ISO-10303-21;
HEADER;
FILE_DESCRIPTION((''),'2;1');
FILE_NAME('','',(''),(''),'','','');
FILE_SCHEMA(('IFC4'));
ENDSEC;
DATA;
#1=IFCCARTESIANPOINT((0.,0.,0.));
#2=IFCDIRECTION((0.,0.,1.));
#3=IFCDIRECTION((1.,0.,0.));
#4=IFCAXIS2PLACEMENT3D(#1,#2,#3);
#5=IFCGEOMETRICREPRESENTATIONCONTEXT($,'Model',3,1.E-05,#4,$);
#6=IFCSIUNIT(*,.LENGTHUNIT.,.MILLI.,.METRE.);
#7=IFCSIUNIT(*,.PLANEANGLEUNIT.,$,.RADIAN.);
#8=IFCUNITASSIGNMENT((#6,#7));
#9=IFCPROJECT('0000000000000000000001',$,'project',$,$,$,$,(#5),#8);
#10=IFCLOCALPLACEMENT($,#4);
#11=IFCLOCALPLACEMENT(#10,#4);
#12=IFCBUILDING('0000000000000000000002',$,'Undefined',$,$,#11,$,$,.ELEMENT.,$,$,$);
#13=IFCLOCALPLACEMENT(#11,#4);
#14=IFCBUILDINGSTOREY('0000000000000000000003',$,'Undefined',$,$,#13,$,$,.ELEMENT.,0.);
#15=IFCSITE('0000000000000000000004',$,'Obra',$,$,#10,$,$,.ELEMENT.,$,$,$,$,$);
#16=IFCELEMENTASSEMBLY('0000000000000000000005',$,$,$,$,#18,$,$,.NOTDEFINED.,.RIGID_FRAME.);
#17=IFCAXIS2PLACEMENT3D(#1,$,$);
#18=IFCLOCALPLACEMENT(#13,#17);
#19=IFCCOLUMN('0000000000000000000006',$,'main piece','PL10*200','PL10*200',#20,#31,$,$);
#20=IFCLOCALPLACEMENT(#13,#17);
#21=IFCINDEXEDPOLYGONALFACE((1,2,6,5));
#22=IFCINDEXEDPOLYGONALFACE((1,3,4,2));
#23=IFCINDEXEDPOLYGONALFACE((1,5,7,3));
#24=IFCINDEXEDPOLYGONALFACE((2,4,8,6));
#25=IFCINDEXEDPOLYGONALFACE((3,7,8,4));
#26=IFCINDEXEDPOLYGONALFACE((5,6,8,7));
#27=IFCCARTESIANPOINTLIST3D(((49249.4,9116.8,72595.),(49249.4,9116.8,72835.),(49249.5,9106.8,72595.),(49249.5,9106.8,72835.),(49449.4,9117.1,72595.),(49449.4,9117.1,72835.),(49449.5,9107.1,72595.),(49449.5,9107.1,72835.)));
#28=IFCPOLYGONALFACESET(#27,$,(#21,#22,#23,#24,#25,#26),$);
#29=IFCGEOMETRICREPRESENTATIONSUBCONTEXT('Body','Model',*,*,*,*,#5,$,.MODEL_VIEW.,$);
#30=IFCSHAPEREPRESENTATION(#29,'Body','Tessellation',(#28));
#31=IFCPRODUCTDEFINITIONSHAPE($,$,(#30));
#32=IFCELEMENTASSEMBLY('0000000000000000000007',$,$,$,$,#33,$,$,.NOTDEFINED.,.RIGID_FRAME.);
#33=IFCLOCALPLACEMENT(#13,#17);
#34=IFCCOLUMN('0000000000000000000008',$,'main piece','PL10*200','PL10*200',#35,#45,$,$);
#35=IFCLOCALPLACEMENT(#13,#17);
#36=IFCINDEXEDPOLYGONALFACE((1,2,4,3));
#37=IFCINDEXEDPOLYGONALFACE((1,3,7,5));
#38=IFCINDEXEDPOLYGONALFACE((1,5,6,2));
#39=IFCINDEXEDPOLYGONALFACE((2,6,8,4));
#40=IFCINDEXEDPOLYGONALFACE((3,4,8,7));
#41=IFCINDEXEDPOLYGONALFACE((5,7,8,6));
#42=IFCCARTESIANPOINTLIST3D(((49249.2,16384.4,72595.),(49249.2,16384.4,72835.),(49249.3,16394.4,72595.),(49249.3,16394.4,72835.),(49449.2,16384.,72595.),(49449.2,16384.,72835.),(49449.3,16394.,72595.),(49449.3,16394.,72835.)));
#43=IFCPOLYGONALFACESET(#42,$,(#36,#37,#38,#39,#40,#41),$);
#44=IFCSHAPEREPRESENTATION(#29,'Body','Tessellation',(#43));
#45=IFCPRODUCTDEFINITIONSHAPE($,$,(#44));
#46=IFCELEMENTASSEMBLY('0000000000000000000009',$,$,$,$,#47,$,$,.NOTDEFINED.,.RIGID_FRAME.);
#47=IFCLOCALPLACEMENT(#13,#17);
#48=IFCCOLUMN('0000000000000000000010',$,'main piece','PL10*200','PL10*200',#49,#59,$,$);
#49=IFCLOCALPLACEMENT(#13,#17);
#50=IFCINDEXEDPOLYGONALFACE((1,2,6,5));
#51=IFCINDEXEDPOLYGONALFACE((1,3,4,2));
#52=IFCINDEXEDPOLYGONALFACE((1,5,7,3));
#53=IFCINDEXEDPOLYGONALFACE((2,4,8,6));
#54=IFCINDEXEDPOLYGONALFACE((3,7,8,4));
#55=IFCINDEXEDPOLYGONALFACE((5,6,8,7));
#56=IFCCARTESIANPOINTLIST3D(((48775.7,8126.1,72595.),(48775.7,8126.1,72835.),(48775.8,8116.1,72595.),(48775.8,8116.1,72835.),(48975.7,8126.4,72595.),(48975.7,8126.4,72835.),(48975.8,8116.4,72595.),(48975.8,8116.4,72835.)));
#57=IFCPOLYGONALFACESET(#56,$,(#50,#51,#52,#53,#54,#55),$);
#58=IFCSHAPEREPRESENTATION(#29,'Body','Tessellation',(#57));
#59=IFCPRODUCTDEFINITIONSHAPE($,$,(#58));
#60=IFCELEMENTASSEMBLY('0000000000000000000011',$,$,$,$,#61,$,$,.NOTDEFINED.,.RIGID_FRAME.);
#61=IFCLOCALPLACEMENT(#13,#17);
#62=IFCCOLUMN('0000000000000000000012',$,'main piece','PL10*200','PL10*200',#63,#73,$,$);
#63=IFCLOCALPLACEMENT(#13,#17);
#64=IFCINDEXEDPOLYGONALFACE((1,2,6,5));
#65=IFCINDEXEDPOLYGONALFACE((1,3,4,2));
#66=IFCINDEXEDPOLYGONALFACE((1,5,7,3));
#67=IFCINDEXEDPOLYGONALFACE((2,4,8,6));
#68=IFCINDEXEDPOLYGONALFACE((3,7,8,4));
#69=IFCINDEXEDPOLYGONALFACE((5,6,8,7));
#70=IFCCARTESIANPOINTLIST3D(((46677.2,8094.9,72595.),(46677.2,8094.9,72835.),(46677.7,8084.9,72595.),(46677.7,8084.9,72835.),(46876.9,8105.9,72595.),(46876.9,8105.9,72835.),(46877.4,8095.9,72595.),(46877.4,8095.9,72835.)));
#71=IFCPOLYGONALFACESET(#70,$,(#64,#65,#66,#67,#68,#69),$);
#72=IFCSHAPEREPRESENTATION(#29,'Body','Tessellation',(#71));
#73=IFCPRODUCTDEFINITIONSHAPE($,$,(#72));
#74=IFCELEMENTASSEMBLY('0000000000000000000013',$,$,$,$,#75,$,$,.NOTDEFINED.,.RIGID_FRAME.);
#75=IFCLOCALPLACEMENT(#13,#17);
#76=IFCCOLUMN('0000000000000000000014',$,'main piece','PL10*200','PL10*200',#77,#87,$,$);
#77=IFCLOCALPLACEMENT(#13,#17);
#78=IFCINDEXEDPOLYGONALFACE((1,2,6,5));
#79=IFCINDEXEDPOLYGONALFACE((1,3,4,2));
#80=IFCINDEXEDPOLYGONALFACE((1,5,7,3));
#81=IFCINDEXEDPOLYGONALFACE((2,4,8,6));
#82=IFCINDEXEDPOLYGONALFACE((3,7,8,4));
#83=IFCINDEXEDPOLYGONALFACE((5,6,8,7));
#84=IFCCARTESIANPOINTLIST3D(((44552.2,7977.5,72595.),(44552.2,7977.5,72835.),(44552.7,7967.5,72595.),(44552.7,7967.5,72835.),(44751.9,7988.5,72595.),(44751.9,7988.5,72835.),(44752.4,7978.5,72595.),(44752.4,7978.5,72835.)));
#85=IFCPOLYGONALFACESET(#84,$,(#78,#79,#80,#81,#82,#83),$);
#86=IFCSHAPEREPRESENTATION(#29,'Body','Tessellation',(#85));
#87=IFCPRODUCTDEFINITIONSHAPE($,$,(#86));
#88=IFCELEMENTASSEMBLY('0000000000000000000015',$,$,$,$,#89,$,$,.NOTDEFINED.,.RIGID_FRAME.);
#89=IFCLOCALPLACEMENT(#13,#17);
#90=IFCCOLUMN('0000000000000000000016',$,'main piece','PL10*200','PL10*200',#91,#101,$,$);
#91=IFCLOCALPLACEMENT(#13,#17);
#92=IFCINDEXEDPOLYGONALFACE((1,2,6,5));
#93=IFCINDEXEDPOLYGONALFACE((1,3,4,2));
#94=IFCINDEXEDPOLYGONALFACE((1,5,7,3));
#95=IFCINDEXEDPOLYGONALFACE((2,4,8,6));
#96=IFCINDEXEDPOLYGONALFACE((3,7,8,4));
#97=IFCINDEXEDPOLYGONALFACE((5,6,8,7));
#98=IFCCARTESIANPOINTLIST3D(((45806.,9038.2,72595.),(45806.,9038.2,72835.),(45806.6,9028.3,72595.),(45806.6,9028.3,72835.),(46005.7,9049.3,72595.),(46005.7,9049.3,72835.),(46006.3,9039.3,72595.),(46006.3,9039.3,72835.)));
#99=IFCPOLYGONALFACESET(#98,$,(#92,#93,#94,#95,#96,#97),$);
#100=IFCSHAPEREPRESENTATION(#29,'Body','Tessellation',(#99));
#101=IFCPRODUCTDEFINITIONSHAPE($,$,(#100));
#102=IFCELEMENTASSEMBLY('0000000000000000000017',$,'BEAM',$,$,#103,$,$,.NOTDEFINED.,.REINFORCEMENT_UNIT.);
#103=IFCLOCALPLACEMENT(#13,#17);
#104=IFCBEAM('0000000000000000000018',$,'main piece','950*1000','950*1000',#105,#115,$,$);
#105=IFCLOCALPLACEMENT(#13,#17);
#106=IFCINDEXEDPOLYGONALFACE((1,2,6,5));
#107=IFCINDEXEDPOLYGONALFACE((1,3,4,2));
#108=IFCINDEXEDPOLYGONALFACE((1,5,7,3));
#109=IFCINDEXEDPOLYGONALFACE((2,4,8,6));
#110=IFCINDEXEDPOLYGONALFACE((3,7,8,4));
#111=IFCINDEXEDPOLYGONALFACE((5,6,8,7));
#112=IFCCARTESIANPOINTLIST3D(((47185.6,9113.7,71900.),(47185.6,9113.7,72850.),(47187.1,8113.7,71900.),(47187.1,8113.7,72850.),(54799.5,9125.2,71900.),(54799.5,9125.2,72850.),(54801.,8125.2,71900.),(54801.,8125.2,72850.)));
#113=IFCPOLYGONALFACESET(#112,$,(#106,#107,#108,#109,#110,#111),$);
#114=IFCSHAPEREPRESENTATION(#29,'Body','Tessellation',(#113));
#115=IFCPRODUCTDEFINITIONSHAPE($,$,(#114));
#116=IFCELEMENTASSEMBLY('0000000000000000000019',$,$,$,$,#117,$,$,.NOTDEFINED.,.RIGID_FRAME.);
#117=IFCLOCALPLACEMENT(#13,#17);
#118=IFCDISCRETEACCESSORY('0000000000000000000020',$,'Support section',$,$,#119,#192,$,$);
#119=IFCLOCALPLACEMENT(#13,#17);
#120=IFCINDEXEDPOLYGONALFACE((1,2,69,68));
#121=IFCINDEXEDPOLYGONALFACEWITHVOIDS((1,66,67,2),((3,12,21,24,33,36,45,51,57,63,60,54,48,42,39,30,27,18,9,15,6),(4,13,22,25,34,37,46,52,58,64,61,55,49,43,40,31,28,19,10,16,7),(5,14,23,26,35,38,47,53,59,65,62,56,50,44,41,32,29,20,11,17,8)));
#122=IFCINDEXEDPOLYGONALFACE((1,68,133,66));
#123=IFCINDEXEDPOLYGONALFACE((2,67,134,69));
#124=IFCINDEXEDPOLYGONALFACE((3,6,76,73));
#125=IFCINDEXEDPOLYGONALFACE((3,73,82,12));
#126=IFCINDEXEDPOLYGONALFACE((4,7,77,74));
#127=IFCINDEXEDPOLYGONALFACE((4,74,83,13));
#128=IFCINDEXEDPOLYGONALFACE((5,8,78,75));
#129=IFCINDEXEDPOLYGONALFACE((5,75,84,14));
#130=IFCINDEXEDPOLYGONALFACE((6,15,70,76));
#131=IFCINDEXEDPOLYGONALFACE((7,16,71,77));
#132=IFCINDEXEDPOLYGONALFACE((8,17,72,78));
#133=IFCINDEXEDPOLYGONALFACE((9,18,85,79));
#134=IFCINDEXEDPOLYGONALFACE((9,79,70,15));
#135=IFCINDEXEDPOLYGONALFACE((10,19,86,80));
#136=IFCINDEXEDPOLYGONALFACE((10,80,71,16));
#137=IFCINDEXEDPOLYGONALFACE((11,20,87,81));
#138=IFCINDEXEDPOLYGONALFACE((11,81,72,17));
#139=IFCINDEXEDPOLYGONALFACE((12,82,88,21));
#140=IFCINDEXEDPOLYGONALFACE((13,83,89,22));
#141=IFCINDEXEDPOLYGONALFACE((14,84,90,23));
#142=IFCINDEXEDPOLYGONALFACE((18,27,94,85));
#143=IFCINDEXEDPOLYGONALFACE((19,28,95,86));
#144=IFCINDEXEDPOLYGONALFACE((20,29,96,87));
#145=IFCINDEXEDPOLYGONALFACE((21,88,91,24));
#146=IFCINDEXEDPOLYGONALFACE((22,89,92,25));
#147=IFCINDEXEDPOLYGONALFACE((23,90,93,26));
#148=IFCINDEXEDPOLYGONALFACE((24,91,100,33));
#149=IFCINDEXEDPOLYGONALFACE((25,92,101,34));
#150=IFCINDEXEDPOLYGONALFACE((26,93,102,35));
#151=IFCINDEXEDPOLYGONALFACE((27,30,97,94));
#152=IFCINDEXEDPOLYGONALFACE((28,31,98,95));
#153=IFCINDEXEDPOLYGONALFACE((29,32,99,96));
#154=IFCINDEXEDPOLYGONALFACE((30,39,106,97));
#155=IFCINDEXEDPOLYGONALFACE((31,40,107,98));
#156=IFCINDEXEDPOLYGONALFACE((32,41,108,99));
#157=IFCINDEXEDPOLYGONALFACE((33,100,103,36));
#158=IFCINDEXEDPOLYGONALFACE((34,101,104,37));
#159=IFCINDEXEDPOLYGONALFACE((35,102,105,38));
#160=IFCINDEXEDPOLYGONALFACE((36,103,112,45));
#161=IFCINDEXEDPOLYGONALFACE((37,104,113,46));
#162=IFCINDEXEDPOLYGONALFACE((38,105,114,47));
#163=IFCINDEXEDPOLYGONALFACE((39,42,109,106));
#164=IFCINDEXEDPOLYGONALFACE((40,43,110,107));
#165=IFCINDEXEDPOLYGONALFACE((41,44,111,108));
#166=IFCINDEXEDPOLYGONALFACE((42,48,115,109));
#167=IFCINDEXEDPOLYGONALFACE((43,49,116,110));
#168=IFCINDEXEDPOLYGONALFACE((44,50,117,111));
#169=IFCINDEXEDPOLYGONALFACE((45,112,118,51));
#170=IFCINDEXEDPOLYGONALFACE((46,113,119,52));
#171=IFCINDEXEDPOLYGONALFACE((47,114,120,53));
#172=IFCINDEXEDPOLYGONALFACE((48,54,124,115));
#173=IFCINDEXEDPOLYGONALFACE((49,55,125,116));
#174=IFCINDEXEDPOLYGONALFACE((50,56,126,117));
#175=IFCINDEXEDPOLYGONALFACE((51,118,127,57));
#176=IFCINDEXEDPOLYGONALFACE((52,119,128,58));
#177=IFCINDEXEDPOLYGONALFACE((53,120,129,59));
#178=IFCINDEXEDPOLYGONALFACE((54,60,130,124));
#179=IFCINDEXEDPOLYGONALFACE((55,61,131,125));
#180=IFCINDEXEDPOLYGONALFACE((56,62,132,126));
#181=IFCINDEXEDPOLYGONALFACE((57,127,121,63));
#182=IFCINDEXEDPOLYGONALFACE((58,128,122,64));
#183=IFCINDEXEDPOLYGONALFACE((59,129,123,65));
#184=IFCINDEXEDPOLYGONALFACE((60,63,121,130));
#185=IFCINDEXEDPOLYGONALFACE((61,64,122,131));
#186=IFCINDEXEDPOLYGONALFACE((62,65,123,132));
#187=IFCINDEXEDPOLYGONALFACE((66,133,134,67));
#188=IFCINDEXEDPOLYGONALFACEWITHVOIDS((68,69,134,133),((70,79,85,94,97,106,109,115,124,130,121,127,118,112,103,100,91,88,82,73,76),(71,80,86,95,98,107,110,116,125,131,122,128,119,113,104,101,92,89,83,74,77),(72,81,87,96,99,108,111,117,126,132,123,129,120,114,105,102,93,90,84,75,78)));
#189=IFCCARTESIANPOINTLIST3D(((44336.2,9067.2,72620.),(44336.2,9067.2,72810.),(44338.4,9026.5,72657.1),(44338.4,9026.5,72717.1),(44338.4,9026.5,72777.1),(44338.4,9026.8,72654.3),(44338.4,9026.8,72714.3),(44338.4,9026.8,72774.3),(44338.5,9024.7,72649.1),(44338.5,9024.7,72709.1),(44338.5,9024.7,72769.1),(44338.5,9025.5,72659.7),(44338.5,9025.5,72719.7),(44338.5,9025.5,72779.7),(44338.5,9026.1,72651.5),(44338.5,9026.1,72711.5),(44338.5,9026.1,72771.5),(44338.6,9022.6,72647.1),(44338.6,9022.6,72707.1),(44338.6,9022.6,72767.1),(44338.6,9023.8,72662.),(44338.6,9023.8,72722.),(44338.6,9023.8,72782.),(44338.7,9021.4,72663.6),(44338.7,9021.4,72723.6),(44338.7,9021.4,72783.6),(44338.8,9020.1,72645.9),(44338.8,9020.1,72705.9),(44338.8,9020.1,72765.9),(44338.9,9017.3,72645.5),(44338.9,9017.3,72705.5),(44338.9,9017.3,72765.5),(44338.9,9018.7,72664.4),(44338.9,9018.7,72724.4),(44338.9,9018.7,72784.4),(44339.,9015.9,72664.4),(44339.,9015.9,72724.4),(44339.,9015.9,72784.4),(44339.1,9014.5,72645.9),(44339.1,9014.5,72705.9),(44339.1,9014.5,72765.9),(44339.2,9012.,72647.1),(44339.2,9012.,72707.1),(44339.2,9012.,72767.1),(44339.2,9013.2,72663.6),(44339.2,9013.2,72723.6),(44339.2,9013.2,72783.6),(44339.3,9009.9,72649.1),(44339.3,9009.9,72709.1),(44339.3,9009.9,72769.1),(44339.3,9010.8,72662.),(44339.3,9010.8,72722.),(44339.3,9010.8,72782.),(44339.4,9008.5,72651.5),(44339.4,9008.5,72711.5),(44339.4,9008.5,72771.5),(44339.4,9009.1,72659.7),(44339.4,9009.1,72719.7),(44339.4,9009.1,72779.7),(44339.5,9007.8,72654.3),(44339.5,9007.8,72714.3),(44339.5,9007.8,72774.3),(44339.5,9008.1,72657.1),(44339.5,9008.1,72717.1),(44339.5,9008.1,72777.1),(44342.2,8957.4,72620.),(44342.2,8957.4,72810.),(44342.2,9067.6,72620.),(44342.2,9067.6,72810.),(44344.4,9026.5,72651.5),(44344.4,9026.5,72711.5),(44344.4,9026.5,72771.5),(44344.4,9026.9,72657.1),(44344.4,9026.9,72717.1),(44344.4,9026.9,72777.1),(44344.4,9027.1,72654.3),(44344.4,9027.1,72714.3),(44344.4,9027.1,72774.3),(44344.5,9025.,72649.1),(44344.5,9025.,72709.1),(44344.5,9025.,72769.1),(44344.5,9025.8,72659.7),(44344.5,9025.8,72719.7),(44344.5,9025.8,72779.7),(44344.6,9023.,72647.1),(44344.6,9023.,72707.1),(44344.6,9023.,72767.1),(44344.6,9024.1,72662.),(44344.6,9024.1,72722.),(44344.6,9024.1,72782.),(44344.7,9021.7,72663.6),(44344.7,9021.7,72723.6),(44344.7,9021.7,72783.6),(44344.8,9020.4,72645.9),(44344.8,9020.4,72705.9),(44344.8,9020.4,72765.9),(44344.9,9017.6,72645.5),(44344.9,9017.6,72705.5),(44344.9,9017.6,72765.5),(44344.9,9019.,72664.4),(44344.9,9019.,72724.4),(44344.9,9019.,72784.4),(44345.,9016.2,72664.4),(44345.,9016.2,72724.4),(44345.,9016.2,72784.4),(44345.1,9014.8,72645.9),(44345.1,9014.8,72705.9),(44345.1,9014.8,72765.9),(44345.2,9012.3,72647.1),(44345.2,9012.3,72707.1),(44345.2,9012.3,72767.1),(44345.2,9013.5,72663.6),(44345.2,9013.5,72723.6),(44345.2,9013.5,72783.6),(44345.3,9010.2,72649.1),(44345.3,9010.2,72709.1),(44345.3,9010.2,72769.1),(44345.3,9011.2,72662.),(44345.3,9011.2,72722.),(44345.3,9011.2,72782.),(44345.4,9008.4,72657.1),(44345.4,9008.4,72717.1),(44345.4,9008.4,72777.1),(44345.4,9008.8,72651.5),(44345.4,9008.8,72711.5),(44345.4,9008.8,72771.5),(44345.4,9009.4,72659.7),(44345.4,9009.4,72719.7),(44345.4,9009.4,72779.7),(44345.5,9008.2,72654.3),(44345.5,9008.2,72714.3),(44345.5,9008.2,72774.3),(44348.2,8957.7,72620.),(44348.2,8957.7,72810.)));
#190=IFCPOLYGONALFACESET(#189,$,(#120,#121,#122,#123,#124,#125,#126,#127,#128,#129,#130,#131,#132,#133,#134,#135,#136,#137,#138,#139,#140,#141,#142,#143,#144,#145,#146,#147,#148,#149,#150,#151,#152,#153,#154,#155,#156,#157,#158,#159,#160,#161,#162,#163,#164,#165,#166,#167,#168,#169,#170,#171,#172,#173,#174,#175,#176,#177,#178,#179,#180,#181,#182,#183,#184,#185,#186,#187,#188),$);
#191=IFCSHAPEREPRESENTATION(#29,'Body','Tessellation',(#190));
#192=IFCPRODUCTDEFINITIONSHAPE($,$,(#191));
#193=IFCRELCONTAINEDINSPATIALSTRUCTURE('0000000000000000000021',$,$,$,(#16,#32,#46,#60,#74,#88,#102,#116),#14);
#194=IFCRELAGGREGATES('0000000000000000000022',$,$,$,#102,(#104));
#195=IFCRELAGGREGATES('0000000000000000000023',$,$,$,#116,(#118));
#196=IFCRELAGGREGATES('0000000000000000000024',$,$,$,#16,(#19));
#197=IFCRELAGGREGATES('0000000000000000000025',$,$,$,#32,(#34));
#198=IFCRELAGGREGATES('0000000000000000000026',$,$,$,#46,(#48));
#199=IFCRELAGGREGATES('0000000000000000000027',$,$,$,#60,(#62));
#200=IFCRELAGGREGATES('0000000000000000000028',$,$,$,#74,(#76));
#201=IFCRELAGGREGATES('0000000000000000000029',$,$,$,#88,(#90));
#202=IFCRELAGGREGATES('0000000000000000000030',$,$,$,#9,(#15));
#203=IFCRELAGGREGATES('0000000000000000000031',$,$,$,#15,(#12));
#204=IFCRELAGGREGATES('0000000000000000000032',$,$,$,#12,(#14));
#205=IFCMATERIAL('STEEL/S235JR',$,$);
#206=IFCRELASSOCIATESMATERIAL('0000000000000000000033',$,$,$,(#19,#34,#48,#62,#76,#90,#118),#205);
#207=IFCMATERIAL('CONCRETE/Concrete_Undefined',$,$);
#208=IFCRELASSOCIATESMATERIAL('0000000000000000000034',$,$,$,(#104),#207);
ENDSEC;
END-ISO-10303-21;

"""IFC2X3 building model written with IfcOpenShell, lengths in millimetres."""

from ifc_helpers import new_model, si_unit, frame, origin_with_axes, origin_2d_with_axis, place, context, subcontext, project, spatial, rectangle, circle, extrude, source, transform, mapped, material, element, aggregate, save


model = new_model("IFC2X3")

# Units and contexts
model_context = context("Model", 3, precision=1e-05, world=origin_with_axes())
body_context = subcontext(model_context, "Body", "Model", "MODEL_VIEW")
ifc_project = project(units=[si_unit("LENGTHUNIT", "METRE", prefix="MILLI"), si_unit("PLANEANGLEUNIT", "RADIAN")], contexts=[model_context])

# Site, building, storey
site_placement = place(None, origin_with_axes())
site = spatial("IfcSite", under=ifc_project, at=site_placement, Name="Obra", CompositionType="ELEMENT")
building_placement = place(site_placement, origin_with_axes())
building = spatial("IfcBuilding", under=site, at=building_placement, Name="Undefined", CompositionType="ELEMENT")
storey_placement = place(building_placement, origin_with_axes())
storey = spatial("IfcBuildingStorey", under=building, at=storey_placement, Name="Undefined", CompositionType="ELEMENT", Elevation=0.0)

# Element assemblies, columns
assembly_1_placement = place(storey_placement, origin_with_axes())
assembly_1 = element("IfcElementAssembly", 1, at=assembly_1_placement, inside=storey, AssemblyPlace="NOTDEFINED", PredefinedType="RIGID_FRAME")
ifc_material_1 = material(Name="STEEL/S235JR")
column_1_placement = place(assembly_1_placement, frame((49349.4, 9112.0, 72595.0), z_axis=(0.0, 0.0, 1.0), x_axis=(0.999999, 0.001508, 0.0)))
column_1 = element("IfcColumn", 2, at=column_1_placement, material=ifc_material_1, Name="main piece", Description="PL10*200", ObjectType="PL10*200", context=body_context, shape_type="SweptSolid", body=[
    extrude(rectangle(XDim=10.0, YDim=200.0, at=origin_2d_with_axis()), frame((0.0, 0.0, 240.0), z_axis=(0.0, 0.0, -1.0), x_axis=(0.0, 1.0, 0.0)), (0.0, 0.0, 1.0), 240.0),
])
assembly_2_placement = place(storey_placement, origin_with_axes())
assembly_2 = element("IfcElementAssembly", 3, at=assembly_2_placement, inside=storey, AssemblyPlace="NOTDEFINED", PredefinedType="RIGID_FRAME")
column_2_placement = place(assembly_2_placement, frame((49349.3, 16389.2, 72595.0), z_axis=(0.0, 0.0, 1.0), x_axis=(-0.999999, 0.001649, 0.0)))
column_2 = element("IfcColumn", 4, at=column_2_placement, material=ifc_material_1, Name="main piece", Description="PL10*200", ObjectType="PL10*200", context=body_context, shape_type="SweptSolid", body=[
    extrude(rectangle(XDim=10.0, YDim=200.0, at=origin_2d_with_axis()), frame((0.0, 0.0, 240.0), z_axis=(0.0, 0.0, -1.0), x_axis=(0.0, 1.0, 0.0)), (0.0, 0.0, 1.0), 240.0),
])
assembly_3_placement = place(storey_placement, origin_with_axes())
assembly_3 = element("IfcElementAssembly", 5, at=assembly_3_placement, inside=storey, AssemblyPlace="NOTDEFINED", PredefinedType="RIGID_FRAME")
column_3_placement = place(assembly_3_placement, frame((48875.7, 8121.3, 72595.0), z_axis=(0.0, 0.0, 1.0), x_axis=(-0.999999, -0.001508, 0.0)))
column_3 = element("IfcColumn", 6, at=column_3_placement, material=ifc_material_1, Name="main piece", Description="PL10*200", ObjectType="PL10*200", context=body_context, shape_type="SweptSolid", body=[
    extrude(rectangle(XDim=10.0, YDim=200.0, at=origin_2d_with_axis()), frame((0.0, 0.0, 240.0), z_axis=(0.0, 0.0, -1.0), x_axis=(0.0, 1.0, 0.0)), (0.0, 0.0, 1.0), 240.0),
])
assembly_4_placement = place(storey_placement, origin_with_axes())
assembly_4 = element("IfcElementAssembly", 7, at=assembly_4_placement, inside=storey, AssemblyPlace="NOTDEFINED", PredefinedType="RIGID_FRAME")
column_4_placement = place(assembly_4_placement, frame((46777.3, 8095.4, 72595.0), z_axis=(0.0, 0.0, 1.0), x_axis=(-0.998478, -0.055152, 0.0)))
column_4 = element("IfcColumn", 8, at=column_4_placement, material=ifc_material_1, Name="main piece", Description="PL10*200", ObjectType="PL10*200", context=body_context, shape_type="SweptSolid", body=[
    extrude(rectangle(XDim=10.0, YDim=200.0, at=origin_2d_with_axis()), frame((0.0, 0.0, 240.0), z_axis=(0.0, 0.0, -1.0), x_axis=(0.0, 1.0, 0.0)), (0.0, 0.0, 1.0), 240.0),
])
assembly_5_placement = place(storey_placement, origin_with_axes())
assembly_5 = element("IfcElementAssembly", 9, at=assembly_5_placement, inside=storey, AssemblyPlace="NOTDEFINED", PredefinedType="RIGID_FRAME")
column_5_placement = place(assembly_5_placement, frame((44652.3, 7978.0, 72595.0), z_axis=(0.0, 0.0, 1.0), x_axis=(-0.998478, -0.055152, 0.0)))
column_5 = element("IfcColumn", 10, at=column_5_placement, material=ifc_material_1, Name="main piece", Description="PL10*200", ObjectType="PL10*200", context=body_context, shape_type="SweptSolid", body=[
    extrude(rectangle(XDim=10.0, YDim=200.0, at=origin_2d_with_axis()), frame((0.0, 0.0, 240.0), z_axis=(0.0, 0.0, -1.0), x_axis=(0.0, 1.0, 0.0)), (0.0, 0.0, 1.0), 240.0),
])
assembly_6_placement = place(storey_placement, origin_with_axes())
assembly_6 = element("IfcElementAssembly", 11, at=assembly_6_placement, inside=storey, AssemblyPlace="NOTDEFINED", PredefinedType="RIGID_FRAME")
column_6_placement = place(assembly_6_placement, frame((45906.2, 9038.8, 72595.0), z_axis=(0.0, 0.0, 1.0), x_axis=(0.998478, 0.055152, 0.0)))
column_6 = element("IfcColumn", 12, at=column_6_placement, material=ifc_material_1, Name="main piece", Description="PL10*200", ObjectType="PL10*200", context=body_context, shape_type="SweptSolid", body=[
    extrude(rectangle(XDim=10.0, YDim=200.0, at=origin_2d_with_axis()), frame((0.0, 0.0, 240.0), z_axis=(0.0, 0.0, -1.0), x_axis=(0.0, 1.0, 0.0)), (0.0, 0.0, 1.0), 240.0),
])

# Element assembly, beam
assembly_7_placement = place(storey_placement, origin_with_axes())
assembly_7 = element("IfcElementAssembly", 13, at=assembly_7_placement, inside=storey, Name="BEAM", AssemblyPlace="NOTDEFINED", PredefinedType="REINFORCEMENT_UNIT")
ifc_material_2 = material(Name="CONCRETE/Concrete_Undefined")
beam_placement = place(assembly_7_placement, frame((47186.4, 8613.7, 72375.0), z_axis=(0.0, 0.0, 1.0), x_axis=(0.999999, 0.001508, 0.0)))
beam = element("IfcBeam", 14, at=beam_placement, material=ifc_material_2, Name="main piece", Description="950*1000", ObjectType="950*1000", context=body_context, shape_type="SweptSolid", body=[
    extrude(rectangle(XDim=1000.0, YDim=950.0, at=origin_2d_with_axis()), frame((7613.8, 0.0, 0.0), z_axis=(-1.0, 0.0, 0.0), x_axis=(0.0, -1.0, 0.0)), (0.0, 0.0, 1.0), 7613.8),
])
aggregate(assembly_7, [beam])

# Element assembly, discrete accessory, opening
assembly_8_placement = place(storey_placement, origin_with_axes())
assembly_8 = element("IfcElementAssembly", 15, at=assembly_8_placement, inside=storey, AssemblyPlace="NOTDEFINED", PredefinedType="RIGID_FRAME")
discrete_accessory_1_placement = place(assembly_8_placement, frame((44342.2, 9012.5, 72620.0), z_axis=(0.0, 0.0, 1.0), x_axis=(0.055152, -0.998478, 0.0)))
discrete_accessory_1 = element("IfcDiscreteAccessory", 16, at=discrete_accessory_1_placement, material=ifc_material_1, Name="Support section", context=body_context, shape_type="SweptSolid", body=[
    extrude(rectangle(XDim=6.0, YDim=110.0, at=origin_2d_with_axis()), frame((0.0, 0.0, 190.0), z_axis=(0.0, 0.0, -1.0), x_axis=(0.0, 1.0, 0.0)), (0.0, 0.0, 1.0), 190.0),
])
shared_shape = source(origin_with_axes(), body_context, "Body", "SweptSolid", [
    extrude(circle(Radius=9.5, at=origin_2d_with_axis()), frame((0.0, -9.2, 0.0), z_axis=(0.0, 1.0, 0.0), x_axis=(1.0, 0.0, 0.0)), (0.0, 0.0, 1.0), 6.2),
])
opening_1_placement = place(assembly_8_placement, frame((44338.6, 8967.2, 72835.0), z_axis=(-0.055152, 0.998478, 0.0), x_axis=(0.0, 0.0, -1.0)))
element("IfcOpeningElement", 17, at=opening_1_placement, cuts=discrete_accessory_1, ObjectType="Opening", context=body_context, shape_type="MappedRepresentation", body=[
    mapped(shared_shape, transform((60.0, 0.0, 50.0))),
    mapped(shared_shape, transform((120.0, 0.0, 50.0))),
    mapped(shared_shape, transform((180.0, 0.0, 50.0))),
])
aggregate(assembly_8, [discrete_accessory_1])

aggregate(assembly_1, [column_1])
aggregate(assembly_2, [column_2])
aggregate(assembly_3, [column_3])
aggregate(assembly_4, [column_4])
aggregate(assembly_5, [column_5])
aggregate(assembly_6, [column_6])

save(model, "model.ifc")
